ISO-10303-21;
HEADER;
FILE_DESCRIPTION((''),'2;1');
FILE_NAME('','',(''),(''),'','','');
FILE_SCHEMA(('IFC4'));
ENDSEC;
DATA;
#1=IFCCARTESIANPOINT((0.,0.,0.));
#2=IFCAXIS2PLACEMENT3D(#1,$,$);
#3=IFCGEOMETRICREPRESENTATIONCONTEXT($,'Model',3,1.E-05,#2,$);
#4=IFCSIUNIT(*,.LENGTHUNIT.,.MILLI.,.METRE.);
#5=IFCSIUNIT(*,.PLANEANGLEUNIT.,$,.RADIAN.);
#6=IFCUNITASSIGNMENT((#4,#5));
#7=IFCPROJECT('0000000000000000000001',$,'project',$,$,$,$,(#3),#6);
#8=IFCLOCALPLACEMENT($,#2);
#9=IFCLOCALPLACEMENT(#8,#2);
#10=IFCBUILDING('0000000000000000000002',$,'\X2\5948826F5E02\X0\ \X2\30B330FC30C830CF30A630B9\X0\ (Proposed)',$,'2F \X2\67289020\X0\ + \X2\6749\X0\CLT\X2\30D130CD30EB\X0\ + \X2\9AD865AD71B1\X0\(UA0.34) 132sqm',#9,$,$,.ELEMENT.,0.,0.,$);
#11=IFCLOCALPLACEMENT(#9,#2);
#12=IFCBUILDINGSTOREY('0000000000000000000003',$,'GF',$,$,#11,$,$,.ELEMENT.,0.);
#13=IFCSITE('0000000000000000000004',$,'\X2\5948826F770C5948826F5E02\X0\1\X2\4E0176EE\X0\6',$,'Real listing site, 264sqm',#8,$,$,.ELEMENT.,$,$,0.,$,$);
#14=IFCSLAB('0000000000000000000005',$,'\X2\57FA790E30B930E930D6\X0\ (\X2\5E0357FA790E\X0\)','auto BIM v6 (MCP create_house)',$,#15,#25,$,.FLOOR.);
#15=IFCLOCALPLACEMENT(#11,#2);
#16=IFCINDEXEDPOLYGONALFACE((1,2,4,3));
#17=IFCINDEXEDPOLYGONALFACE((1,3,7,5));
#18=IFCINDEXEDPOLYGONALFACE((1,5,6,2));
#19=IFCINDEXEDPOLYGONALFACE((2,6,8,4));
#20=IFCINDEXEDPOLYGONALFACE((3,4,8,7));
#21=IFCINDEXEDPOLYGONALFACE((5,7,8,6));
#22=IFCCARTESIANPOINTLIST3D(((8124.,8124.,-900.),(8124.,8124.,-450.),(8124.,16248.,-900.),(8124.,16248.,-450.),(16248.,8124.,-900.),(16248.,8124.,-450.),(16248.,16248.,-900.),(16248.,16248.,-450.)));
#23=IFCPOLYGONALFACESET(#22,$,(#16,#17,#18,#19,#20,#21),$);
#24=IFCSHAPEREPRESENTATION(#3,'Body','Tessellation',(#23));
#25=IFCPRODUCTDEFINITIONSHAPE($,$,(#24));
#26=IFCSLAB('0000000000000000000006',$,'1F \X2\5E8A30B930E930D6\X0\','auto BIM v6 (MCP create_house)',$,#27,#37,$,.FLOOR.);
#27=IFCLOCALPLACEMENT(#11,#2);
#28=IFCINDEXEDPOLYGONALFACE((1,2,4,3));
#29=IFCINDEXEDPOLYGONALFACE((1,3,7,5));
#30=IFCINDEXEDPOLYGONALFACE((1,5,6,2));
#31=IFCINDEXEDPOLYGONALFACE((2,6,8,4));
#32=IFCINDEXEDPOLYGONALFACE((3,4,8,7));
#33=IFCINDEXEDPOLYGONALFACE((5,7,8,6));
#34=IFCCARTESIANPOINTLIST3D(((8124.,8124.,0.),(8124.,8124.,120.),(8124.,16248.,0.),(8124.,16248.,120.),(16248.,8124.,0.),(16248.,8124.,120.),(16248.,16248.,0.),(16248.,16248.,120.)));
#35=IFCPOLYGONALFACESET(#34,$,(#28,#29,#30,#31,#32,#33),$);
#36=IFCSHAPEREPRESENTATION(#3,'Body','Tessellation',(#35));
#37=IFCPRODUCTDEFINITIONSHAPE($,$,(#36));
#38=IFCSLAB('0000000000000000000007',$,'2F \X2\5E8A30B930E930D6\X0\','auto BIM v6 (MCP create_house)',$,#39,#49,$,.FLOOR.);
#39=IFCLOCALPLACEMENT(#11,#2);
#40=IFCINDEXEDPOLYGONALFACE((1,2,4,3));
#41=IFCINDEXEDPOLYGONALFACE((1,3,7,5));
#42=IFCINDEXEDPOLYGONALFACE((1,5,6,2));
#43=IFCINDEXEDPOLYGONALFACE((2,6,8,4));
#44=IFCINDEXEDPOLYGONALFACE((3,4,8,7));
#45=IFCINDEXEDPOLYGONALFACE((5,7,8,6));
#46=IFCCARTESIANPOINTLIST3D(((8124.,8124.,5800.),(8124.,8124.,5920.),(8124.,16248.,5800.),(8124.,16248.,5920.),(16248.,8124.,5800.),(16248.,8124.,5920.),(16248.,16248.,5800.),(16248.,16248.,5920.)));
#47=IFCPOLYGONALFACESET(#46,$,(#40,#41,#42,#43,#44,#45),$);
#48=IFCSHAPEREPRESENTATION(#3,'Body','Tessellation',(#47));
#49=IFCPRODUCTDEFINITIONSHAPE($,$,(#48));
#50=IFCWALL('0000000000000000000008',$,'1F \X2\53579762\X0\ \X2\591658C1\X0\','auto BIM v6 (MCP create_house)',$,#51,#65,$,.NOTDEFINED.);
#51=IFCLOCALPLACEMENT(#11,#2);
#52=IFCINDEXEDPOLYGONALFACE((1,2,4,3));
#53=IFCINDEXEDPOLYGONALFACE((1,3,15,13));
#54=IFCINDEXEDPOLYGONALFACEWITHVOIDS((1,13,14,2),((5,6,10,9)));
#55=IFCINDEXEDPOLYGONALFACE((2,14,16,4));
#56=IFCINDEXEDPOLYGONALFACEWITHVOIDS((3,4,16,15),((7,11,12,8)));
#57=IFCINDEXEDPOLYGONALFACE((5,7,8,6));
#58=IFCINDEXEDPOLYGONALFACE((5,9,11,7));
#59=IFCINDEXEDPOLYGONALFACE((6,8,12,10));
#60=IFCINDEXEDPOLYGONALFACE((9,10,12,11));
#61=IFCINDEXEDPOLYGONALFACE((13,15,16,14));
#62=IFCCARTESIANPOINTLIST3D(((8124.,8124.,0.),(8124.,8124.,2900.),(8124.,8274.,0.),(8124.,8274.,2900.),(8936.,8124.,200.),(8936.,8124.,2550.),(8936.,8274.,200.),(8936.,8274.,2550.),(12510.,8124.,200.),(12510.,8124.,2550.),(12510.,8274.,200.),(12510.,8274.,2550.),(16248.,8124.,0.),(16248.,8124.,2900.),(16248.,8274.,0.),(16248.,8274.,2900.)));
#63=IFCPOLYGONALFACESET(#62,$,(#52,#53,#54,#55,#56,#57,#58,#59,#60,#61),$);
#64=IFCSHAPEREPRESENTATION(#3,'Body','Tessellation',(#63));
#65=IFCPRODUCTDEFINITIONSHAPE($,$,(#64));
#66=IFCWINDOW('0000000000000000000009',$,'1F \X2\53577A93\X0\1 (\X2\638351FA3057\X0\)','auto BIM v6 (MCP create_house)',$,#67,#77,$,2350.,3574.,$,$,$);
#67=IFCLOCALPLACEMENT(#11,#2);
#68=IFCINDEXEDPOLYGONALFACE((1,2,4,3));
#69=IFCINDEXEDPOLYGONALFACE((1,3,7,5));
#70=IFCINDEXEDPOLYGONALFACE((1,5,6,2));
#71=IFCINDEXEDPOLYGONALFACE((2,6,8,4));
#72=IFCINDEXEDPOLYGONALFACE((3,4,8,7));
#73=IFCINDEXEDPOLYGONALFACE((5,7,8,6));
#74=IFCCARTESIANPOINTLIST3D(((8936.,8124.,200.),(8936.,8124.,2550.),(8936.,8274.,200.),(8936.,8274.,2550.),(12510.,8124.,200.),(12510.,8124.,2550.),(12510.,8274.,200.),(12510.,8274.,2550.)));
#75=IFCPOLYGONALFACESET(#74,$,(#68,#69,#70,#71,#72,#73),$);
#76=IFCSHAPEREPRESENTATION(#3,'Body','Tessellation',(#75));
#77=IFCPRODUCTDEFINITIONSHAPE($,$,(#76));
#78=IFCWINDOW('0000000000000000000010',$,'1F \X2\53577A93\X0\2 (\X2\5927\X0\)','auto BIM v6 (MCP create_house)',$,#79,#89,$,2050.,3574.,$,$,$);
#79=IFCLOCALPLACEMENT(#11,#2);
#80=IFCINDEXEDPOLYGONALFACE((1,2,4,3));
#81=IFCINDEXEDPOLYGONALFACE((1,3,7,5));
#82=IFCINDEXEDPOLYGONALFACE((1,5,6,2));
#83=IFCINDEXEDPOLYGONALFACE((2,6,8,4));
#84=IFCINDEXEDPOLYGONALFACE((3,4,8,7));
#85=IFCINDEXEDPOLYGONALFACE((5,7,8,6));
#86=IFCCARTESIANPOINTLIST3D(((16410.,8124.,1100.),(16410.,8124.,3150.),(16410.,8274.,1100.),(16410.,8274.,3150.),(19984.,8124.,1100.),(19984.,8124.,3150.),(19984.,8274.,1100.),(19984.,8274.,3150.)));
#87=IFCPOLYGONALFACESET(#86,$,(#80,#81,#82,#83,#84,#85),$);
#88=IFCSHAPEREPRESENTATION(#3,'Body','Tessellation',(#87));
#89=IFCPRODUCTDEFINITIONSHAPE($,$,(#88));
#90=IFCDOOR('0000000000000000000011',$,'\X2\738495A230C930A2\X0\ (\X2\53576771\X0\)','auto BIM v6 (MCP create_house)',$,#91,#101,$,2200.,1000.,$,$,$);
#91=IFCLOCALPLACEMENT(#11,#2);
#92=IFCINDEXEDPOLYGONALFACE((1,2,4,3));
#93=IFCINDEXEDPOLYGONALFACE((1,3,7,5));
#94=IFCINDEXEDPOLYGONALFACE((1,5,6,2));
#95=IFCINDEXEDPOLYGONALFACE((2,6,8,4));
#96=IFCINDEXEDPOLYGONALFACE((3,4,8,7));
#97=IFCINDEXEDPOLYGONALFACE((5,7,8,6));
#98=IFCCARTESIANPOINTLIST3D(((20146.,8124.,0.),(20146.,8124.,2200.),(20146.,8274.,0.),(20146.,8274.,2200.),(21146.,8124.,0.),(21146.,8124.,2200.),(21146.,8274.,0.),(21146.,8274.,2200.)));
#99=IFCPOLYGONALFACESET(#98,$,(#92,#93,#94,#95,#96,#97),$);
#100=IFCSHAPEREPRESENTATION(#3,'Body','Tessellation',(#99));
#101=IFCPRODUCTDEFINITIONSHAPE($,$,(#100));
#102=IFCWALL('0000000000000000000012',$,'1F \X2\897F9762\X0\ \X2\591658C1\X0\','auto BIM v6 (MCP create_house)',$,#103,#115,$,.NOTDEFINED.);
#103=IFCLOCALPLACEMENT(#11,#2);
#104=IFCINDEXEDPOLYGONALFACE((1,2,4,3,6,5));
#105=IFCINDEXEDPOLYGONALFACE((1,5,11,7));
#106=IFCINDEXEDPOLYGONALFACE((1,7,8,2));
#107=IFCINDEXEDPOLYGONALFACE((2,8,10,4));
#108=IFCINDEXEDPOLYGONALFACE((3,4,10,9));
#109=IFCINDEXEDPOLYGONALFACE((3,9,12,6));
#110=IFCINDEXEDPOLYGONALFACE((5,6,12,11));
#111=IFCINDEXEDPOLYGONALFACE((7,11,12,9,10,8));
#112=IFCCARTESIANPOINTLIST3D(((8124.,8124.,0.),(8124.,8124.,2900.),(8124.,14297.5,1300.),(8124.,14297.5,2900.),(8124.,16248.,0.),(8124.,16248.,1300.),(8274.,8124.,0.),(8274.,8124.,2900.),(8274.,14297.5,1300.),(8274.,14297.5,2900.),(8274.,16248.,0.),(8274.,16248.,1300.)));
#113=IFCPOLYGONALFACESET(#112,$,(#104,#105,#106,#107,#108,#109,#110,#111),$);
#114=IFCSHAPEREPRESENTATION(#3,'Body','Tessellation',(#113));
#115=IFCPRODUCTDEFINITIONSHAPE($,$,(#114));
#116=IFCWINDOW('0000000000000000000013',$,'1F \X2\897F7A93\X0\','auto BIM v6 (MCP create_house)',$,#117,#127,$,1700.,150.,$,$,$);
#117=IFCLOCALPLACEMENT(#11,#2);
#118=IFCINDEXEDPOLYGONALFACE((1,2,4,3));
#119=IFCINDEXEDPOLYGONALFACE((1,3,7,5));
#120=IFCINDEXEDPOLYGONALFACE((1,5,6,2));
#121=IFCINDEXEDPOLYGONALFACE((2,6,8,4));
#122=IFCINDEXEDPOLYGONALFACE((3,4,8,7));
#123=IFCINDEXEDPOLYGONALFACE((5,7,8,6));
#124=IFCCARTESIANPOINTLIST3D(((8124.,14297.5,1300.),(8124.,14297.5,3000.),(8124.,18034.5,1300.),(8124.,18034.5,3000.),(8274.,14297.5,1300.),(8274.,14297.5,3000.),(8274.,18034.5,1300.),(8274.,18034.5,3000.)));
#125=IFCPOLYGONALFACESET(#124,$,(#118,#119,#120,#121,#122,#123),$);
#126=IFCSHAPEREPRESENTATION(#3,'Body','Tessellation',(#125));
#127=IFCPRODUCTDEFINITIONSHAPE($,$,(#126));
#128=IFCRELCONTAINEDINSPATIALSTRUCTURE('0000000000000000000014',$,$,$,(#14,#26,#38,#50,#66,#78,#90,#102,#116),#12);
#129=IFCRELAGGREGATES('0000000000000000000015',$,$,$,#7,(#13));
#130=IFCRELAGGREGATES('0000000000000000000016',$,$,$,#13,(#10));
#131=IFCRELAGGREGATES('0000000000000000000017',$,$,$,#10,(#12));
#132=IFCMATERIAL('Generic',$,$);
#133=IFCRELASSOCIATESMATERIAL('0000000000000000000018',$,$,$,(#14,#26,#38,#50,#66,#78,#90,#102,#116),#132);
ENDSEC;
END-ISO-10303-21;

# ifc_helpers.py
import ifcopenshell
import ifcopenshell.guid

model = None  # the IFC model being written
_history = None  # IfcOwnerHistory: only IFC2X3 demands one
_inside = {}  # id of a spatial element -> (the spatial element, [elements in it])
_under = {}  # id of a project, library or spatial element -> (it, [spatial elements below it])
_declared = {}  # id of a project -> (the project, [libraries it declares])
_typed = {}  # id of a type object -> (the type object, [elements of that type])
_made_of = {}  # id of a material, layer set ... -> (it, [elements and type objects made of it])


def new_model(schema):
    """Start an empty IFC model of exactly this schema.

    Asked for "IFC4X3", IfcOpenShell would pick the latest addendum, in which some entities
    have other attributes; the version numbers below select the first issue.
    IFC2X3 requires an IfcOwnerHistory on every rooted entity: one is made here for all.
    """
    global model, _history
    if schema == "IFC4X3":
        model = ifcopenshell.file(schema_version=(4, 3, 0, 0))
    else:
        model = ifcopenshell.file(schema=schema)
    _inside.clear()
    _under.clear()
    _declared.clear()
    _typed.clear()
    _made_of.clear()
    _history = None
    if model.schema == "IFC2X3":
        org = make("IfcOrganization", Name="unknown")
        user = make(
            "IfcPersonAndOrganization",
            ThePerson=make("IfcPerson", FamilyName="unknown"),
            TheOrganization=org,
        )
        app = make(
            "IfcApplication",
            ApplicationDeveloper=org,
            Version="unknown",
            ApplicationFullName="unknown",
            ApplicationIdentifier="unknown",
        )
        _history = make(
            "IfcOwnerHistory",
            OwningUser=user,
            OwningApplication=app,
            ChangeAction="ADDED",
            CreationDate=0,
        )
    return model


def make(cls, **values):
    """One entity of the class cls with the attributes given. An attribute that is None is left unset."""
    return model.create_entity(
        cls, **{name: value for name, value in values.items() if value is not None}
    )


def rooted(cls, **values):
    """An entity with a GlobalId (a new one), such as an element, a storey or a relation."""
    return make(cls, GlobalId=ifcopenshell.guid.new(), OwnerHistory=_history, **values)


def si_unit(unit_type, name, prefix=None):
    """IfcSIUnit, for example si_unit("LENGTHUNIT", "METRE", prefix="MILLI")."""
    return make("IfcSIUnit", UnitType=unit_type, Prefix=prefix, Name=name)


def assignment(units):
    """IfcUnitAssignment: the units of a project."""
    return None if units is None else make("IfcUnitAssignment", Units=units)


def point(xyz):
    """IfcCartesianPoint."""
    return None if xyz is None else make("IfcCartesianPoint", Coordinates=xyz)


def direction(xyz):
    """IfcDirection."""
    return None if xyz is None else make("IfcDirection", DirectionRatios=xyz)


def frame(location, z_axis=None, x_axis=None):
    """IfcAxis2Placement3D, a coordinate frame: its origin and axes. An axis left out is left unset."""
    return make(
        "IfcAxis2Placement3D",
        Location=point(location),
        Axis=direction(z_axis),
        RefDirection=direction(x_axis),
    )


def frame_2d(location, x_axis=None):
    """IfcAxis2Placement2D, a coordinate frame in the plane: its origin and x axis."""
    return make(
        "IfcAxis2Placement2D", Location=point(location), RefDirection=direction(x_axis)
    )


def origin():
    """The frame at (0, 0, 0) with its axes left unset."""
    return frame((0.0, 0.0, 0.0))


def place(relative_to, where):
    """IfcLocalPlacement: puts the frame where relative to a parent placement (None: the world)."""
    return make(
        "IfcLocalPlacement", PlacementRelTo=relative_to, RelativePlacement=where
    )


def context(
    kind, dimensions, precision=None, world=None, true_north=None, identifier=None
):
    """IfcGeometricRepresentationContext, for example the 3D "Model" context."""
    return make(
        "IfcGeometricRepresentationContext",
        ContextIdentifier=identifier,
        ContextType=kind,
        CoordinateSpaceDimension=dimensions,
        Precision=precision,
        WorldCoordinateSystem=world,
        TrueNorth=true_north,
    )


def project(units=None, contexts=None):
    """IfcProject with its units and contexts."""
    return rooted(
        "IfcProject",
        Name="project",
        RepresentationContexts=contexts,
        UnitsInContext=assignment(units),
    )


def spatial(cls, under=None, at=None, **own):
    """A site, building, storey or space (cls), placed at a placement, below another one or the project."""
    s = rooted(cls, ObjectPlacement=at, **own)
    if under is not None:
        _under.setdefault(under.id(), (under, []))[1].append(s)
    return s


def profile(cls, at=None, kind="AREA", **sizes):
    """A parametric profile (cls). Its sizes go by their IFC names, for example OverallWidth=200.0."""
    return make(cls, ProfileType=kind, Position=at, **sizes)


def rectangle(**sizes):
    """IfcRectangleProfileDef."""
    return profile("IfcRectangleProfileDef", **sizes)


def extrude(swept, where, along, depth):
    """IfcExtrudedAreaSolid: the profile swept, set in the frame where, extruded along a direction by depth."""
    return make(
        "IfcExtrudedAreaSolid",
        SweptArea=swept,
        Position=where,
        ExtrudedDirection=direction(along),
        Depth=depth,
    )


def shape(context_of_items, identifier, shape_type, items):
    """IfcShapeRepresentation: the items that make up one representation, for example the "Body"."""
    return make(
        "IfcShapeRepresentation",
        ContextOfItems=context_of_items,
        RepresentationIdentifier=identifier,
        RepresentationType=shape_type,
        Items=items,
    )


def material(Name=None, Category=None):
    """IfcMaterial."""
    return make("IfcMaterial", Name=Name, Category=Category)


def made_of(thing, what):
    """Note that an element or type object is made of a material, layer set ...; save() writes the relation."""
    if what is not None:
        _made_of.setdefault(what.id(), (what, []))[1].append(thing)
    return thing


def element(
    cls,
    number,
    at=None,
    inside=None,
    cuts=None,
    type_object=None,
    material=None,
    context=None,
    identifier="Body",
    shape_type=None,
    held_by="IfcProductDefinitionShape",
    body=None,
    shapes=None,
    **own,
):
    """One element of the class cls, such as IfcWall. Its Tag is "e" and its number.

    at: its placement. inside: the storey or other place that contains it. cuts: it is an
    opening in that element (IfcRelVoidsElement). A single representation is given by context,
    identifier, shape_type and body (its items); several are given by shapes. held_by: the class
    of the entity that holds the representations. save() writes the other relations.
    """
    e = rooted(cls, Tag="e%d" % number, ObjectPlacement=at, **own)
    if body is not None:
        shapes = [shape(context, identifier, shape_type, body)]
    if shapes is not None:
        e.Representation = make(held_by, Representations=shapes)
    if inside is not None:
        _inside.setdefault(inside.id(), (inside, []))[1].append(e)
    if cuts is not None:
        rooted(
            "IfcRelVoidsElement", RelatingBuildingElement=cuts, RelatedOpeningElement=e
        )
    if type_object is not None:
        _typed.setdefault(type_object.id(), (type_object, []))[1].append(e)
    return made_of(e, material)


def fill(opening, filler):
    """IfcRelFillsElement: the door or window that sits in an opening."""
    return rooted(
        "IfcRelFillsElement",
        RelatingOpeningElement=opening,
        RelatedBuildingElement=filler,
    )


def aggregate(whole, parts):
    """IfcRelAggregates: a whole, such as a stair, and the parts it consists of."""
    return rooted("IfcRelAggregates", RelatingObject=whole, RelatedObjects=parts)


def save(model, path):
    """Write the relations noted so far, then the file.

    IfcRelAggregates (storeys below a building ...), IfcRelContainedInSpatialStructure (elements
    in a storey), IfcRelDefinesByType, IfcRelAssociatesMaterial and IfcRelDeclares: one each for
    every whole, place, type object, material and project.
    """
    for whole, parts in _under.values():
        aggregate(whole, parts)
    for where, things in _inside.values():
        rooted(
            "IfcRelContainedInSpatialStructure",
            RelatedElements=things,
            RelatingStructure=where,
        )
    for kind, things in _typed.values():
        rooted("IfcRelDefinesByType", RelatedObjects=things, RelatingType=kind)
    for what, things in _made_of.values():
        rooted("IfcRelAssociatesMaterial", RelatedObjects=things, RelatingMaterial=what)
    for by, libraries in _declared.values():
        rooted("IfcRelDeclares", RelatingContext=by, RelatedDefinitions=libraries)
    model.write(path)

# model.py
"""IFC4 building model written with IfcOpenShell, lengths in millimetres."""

from ifc_helpers import new_model, si_unit, frame, frame_2d, origin, place, context, project, spatial, rectangle, extrude, material, element, fill, save


model = new_model("IFC4")

# Units and contexts
model_context = context("Model", 3, precision=1e-05, world=origin())
ifc_project = project(units=[si_unit("LENGTHUNIT", "METRE", prefix="MILLI"), si_unit("PLANEANGLEUNIT", "RADIAN")], contexts=[model_context])

# Site, building, storey
site_placement = place(None, origin())
site = spatial("IfcSite", under=ifc_project, at=site_placement, Name="奈良県奈良市1丁目6", ObjectType="Real listing site, 264sqm", CompositionType="ELEMENT", RefElevation=0.0)
building_placement = place(site_placement, origin())
building = spatial("IfcBuilding", under=site, at=building_placement, Name="奈良市 コートハウス (Proposed)", ObjectType="2F 木造 + 杉CLTパネル + 高断熱(UA0.34) 132sqm", CompositionType="ELEMENT", ElevationOfRefHeight=0.0, ElevationOfTerrain=0.0)
storey_placement = place(building_placement, origin())
storey = spatial("IfcBuildingStorey", under=building, at=storey_placement, Name="GF", CompositionType="ELEMENT", Elevation=0.0)

# Slabs
ifc_material = material(Name="Generic")
slab_1_placement = place(storey_placement, frame((4062.0, 4062.0, -450.0)))
element("IfcSlab", 1, at=slab_1_placement, inside=storey, material=ifc_material, Name="基礎スラブ (布基礎)", Description="auto BIM v6 (MCP create_house)", PredefinedType="FLOOR", context=model_context, shape_type="SweptSolid", body=[
    extrude(rectangle(XDim=8124.0, YDim=8124.0, at=frame_2d((4062.0, 4062.0))), frame((4062.0, 4062.0, -450.0)), (0.0, 0.0, 1.0), 450.0),
])
slab_2_placement = place(storey_placement, frame((4062.0, 4062.0, 0.0)))
element("IfcSlab", 2, at=slab_2_placement, inside=storey, material=ifc_material, Name="1F 床スラブ", Description="auto BIM v6 (MCP create_house)", PredefinedType="FLOOR", context=model_context, shape_type="SweptSolid", body=[
    extrude(rectangle(XDim=8124.0, YDim=8124.0, at=frame_2d((4062.0, 4062.0))), frame((4062.0, 4062.0, 0.0)), (0.0, 0.0, 1.0), 120.0),
])
slab_3_placement = place(storey_placement, frame((4062.0, 4062.0, 2900.0)))
element("IfcSlab", 3, at=slab_3_placement, inside=storey, material=ifc_material, Name="2F 床スラブ", Description="auto BIM v6 (MCP create_house)", PredefinedType="FLOOR", context=model_context, shape_type="SweptSolid", body=[
    extrude(rectangle(XDim=8124.0, YDim=8124.0, at=frame_2d((4062.0, 4062.0))), frame((4062.0, 4062.0, 2900.0)), (0.0, 0.0, 1.0), 120.0),
])

# Wall, openings, windows, door
wall_1_placement = place(storey_placement, frame((4062.0, 4062.0, 0.0)))
wall_1 = element("IfcWall", 4, at=wall_1_placement, inside=storey, material=ifc_material, Name="1F 南面 外壁", Description="auto BIM v6 (MCP create_house)", PredefinedType="NOTDEFINED", context=model_context, shape_type="SweptSolid", body=[
    extrude(rectangle(XDim=8124.0, YDim=150.0, at=frame_2d((4062.0, 75.0))), frame((4062.0, 4062.0, 0.0)), (0.0, 0.0, 1.0), 2900.0),
])
opening_1_placement = place(storey_placement, frame((4468.0, 4062.0, 100.0)))
opening_1 = element("IfcOpeningElement", 5, at=opening_1_placement, cuts=wall_1, PredefinedType="NOTDEFINED", context=model_context, shape_type="SweptSolid", body=[
    extrude(rectangle(XDim=3574.0, YDim=150.0, at=frame_2d((1787.0, 75.0))), frame((4468.0, 4062.0, 100.0)), (0.0, 0.0, 1.0), 2350.0),
])
opening_2_placement = place(storey_placement, frame((8205.0, 4062.0, 550.0)))
opening_2 = element("IfcOpeningElement", 6, at=opening_2_placement, cuts=wall_1, PredefinedType="NOTDEFINED", context=model_context, shape_type="SweptSolid", body=[
    extrude(rectangle(XDim=3574.0, YDim=150.0, at=frame_2d((1787.0, 75.0))), frame((8205.0, 4062.0, 550.0)), (0.0, 0.0, 1.0), 2050.0),
])
opening_3_placement = place(storey_placement, frame((10073.0, 4062.0, 0.0)))
opening_3 = element("IfcOpeningElement", 7, at=opening_3_placement, cuts=wall_1, PredefinedType="NOTDEFINED", context=model_context, shape_type="SweptSolid", body=[
    extrude(rectangle(XDim=1000.0, YDim=150.0, at=frame_2d((500.0, 75.0))), frame((10073.0, 4062.0, 0.0)), (0.0, 0.0, 1.0), 2200.0),
])
window_1_placement = place(storey_placement, frame((4468.0, 4062.0, 100.0)))
window_1 = element("IfcWindow", 8, at=window_1_placement, inside=storey, material=ifc_material, Name="1F 南窓1 (掃出し)", Description="auto BIM v6 (MCP create_house)", OverallHeight=2350.0, OverallWidth=3574.0, context=model_context, shape_type="SweptSolid", body=[
    extrude(rectangle(XDim=3574.0, YDim=150.0, at=frame_2d((1787.0, 75.0))), frame((4468.0, 4062.0, 100.0)), (0.0, 0.0, 1.0), 2350.0),
])
fill(opening_1, window_1)
window_2_placement = place(storey_placement, frame((8205.0, 4062.0, 550.0)))
window_2 = element("IfcWindow", 9, at=window_2_placement, inside=storey, material=ifc_material, Name="1F 南窓2 (大)", Description="auto BIM v6 (MCP create_house)", OverallHeight=2050.0, OverallWidth=3574.0, context=model_context, shape_type="SweptSolid", body=[
    extrude(rectangle(XDim=3574.0, YDim=150.0, at=frame_2d((1787.0, 75.0))), frame((8205.0, 4062.0, 550.0)), (0.0, 0.0, 1.0), 2050.0),
])
fill(opening_2, window_2)
door_placement = place(storey_placement, frame((10073.0, 4062.0, 0.0)))
door = element("IfcDoor", 10, at=door_placement, inside=storey, material=ifc_material, Name="玄関ドア (南東)", Description="auto BIM v6 (MCP create_house)", OverallHeight=2200.0, OverallWidth=1000.0, context=model_context, shape_type="SweptSolid", body=[
    extrude(rectangle(XDim=1000.0, YDim=150.0, at=frame_2d((500.0, 75.0))), frame((10073.0, 4062.0, 0.0)), (0.0, 0.0, 1.0), 2200.0),
])
fill(opening_3, door)

# Wall, opening, window
wall_2_placement = place(storey_placement, frame((4062.0, 4062.0, 0.0)))
wall_2 = element("IfcWall", 11, at=wall_2_placement, inside=storey, material=ifc_material, Name="1F 西面 外壁", Description="auto BIM v6 (MCP create_house)", PredefinedType="NOTDEFINED", context=model_context, shape_type="SweptSolid", body=[
    extrude(rectangle(XDim=150.0, YDim=8124.0, at=frame_2d((75.0, 4062.0))), frame((4062.0, 4062.0, 0.0)), (0.0, 0.0, 1.0), 2900.0),
])
opening_4_placement = place(storey_placement, frame((4062.0, 7149.0, 650.0)))
opening_4 = element("IfcOpeningElement", 12, at=opening_4_placement, cuts=wall_2, PredefinedType="NOTDEFINED", context=model_context, shape_type="SweptSolid", body=[
    extrude(rectangle(XDim=150.0, YDim=3737.0, at=frame_2d((75.0, 1868.0))), frame((4062.0, 7149.0, 650.0)), (0.0, 0.0, 1.0), 1700.0),
])
window_3_placement = place(storey_placement, frame((4062.0, 7149.0, 650.0)))
window_3 = element("IfcWindow", 13, at=window_3_placement, inside=storey, material=ifc_material, Name="1F 西窓", Description="auto BIM v6 (MCP create_house)", OverallHeight=1700.0, OverallWidth=150.0, context=model_context, shape_type="SweptSolid", body=[
    extrude(rectangle(XDim=150.0, YDim=3737.0, at=frame_2d((75.0, 1868.0))), frame((4062.0, 7149.0, 650.0)), (0.0, 0.0, 1.0), 1700.0),
])
fill(opening_4, window_3)

save(model, "model.ifc")
